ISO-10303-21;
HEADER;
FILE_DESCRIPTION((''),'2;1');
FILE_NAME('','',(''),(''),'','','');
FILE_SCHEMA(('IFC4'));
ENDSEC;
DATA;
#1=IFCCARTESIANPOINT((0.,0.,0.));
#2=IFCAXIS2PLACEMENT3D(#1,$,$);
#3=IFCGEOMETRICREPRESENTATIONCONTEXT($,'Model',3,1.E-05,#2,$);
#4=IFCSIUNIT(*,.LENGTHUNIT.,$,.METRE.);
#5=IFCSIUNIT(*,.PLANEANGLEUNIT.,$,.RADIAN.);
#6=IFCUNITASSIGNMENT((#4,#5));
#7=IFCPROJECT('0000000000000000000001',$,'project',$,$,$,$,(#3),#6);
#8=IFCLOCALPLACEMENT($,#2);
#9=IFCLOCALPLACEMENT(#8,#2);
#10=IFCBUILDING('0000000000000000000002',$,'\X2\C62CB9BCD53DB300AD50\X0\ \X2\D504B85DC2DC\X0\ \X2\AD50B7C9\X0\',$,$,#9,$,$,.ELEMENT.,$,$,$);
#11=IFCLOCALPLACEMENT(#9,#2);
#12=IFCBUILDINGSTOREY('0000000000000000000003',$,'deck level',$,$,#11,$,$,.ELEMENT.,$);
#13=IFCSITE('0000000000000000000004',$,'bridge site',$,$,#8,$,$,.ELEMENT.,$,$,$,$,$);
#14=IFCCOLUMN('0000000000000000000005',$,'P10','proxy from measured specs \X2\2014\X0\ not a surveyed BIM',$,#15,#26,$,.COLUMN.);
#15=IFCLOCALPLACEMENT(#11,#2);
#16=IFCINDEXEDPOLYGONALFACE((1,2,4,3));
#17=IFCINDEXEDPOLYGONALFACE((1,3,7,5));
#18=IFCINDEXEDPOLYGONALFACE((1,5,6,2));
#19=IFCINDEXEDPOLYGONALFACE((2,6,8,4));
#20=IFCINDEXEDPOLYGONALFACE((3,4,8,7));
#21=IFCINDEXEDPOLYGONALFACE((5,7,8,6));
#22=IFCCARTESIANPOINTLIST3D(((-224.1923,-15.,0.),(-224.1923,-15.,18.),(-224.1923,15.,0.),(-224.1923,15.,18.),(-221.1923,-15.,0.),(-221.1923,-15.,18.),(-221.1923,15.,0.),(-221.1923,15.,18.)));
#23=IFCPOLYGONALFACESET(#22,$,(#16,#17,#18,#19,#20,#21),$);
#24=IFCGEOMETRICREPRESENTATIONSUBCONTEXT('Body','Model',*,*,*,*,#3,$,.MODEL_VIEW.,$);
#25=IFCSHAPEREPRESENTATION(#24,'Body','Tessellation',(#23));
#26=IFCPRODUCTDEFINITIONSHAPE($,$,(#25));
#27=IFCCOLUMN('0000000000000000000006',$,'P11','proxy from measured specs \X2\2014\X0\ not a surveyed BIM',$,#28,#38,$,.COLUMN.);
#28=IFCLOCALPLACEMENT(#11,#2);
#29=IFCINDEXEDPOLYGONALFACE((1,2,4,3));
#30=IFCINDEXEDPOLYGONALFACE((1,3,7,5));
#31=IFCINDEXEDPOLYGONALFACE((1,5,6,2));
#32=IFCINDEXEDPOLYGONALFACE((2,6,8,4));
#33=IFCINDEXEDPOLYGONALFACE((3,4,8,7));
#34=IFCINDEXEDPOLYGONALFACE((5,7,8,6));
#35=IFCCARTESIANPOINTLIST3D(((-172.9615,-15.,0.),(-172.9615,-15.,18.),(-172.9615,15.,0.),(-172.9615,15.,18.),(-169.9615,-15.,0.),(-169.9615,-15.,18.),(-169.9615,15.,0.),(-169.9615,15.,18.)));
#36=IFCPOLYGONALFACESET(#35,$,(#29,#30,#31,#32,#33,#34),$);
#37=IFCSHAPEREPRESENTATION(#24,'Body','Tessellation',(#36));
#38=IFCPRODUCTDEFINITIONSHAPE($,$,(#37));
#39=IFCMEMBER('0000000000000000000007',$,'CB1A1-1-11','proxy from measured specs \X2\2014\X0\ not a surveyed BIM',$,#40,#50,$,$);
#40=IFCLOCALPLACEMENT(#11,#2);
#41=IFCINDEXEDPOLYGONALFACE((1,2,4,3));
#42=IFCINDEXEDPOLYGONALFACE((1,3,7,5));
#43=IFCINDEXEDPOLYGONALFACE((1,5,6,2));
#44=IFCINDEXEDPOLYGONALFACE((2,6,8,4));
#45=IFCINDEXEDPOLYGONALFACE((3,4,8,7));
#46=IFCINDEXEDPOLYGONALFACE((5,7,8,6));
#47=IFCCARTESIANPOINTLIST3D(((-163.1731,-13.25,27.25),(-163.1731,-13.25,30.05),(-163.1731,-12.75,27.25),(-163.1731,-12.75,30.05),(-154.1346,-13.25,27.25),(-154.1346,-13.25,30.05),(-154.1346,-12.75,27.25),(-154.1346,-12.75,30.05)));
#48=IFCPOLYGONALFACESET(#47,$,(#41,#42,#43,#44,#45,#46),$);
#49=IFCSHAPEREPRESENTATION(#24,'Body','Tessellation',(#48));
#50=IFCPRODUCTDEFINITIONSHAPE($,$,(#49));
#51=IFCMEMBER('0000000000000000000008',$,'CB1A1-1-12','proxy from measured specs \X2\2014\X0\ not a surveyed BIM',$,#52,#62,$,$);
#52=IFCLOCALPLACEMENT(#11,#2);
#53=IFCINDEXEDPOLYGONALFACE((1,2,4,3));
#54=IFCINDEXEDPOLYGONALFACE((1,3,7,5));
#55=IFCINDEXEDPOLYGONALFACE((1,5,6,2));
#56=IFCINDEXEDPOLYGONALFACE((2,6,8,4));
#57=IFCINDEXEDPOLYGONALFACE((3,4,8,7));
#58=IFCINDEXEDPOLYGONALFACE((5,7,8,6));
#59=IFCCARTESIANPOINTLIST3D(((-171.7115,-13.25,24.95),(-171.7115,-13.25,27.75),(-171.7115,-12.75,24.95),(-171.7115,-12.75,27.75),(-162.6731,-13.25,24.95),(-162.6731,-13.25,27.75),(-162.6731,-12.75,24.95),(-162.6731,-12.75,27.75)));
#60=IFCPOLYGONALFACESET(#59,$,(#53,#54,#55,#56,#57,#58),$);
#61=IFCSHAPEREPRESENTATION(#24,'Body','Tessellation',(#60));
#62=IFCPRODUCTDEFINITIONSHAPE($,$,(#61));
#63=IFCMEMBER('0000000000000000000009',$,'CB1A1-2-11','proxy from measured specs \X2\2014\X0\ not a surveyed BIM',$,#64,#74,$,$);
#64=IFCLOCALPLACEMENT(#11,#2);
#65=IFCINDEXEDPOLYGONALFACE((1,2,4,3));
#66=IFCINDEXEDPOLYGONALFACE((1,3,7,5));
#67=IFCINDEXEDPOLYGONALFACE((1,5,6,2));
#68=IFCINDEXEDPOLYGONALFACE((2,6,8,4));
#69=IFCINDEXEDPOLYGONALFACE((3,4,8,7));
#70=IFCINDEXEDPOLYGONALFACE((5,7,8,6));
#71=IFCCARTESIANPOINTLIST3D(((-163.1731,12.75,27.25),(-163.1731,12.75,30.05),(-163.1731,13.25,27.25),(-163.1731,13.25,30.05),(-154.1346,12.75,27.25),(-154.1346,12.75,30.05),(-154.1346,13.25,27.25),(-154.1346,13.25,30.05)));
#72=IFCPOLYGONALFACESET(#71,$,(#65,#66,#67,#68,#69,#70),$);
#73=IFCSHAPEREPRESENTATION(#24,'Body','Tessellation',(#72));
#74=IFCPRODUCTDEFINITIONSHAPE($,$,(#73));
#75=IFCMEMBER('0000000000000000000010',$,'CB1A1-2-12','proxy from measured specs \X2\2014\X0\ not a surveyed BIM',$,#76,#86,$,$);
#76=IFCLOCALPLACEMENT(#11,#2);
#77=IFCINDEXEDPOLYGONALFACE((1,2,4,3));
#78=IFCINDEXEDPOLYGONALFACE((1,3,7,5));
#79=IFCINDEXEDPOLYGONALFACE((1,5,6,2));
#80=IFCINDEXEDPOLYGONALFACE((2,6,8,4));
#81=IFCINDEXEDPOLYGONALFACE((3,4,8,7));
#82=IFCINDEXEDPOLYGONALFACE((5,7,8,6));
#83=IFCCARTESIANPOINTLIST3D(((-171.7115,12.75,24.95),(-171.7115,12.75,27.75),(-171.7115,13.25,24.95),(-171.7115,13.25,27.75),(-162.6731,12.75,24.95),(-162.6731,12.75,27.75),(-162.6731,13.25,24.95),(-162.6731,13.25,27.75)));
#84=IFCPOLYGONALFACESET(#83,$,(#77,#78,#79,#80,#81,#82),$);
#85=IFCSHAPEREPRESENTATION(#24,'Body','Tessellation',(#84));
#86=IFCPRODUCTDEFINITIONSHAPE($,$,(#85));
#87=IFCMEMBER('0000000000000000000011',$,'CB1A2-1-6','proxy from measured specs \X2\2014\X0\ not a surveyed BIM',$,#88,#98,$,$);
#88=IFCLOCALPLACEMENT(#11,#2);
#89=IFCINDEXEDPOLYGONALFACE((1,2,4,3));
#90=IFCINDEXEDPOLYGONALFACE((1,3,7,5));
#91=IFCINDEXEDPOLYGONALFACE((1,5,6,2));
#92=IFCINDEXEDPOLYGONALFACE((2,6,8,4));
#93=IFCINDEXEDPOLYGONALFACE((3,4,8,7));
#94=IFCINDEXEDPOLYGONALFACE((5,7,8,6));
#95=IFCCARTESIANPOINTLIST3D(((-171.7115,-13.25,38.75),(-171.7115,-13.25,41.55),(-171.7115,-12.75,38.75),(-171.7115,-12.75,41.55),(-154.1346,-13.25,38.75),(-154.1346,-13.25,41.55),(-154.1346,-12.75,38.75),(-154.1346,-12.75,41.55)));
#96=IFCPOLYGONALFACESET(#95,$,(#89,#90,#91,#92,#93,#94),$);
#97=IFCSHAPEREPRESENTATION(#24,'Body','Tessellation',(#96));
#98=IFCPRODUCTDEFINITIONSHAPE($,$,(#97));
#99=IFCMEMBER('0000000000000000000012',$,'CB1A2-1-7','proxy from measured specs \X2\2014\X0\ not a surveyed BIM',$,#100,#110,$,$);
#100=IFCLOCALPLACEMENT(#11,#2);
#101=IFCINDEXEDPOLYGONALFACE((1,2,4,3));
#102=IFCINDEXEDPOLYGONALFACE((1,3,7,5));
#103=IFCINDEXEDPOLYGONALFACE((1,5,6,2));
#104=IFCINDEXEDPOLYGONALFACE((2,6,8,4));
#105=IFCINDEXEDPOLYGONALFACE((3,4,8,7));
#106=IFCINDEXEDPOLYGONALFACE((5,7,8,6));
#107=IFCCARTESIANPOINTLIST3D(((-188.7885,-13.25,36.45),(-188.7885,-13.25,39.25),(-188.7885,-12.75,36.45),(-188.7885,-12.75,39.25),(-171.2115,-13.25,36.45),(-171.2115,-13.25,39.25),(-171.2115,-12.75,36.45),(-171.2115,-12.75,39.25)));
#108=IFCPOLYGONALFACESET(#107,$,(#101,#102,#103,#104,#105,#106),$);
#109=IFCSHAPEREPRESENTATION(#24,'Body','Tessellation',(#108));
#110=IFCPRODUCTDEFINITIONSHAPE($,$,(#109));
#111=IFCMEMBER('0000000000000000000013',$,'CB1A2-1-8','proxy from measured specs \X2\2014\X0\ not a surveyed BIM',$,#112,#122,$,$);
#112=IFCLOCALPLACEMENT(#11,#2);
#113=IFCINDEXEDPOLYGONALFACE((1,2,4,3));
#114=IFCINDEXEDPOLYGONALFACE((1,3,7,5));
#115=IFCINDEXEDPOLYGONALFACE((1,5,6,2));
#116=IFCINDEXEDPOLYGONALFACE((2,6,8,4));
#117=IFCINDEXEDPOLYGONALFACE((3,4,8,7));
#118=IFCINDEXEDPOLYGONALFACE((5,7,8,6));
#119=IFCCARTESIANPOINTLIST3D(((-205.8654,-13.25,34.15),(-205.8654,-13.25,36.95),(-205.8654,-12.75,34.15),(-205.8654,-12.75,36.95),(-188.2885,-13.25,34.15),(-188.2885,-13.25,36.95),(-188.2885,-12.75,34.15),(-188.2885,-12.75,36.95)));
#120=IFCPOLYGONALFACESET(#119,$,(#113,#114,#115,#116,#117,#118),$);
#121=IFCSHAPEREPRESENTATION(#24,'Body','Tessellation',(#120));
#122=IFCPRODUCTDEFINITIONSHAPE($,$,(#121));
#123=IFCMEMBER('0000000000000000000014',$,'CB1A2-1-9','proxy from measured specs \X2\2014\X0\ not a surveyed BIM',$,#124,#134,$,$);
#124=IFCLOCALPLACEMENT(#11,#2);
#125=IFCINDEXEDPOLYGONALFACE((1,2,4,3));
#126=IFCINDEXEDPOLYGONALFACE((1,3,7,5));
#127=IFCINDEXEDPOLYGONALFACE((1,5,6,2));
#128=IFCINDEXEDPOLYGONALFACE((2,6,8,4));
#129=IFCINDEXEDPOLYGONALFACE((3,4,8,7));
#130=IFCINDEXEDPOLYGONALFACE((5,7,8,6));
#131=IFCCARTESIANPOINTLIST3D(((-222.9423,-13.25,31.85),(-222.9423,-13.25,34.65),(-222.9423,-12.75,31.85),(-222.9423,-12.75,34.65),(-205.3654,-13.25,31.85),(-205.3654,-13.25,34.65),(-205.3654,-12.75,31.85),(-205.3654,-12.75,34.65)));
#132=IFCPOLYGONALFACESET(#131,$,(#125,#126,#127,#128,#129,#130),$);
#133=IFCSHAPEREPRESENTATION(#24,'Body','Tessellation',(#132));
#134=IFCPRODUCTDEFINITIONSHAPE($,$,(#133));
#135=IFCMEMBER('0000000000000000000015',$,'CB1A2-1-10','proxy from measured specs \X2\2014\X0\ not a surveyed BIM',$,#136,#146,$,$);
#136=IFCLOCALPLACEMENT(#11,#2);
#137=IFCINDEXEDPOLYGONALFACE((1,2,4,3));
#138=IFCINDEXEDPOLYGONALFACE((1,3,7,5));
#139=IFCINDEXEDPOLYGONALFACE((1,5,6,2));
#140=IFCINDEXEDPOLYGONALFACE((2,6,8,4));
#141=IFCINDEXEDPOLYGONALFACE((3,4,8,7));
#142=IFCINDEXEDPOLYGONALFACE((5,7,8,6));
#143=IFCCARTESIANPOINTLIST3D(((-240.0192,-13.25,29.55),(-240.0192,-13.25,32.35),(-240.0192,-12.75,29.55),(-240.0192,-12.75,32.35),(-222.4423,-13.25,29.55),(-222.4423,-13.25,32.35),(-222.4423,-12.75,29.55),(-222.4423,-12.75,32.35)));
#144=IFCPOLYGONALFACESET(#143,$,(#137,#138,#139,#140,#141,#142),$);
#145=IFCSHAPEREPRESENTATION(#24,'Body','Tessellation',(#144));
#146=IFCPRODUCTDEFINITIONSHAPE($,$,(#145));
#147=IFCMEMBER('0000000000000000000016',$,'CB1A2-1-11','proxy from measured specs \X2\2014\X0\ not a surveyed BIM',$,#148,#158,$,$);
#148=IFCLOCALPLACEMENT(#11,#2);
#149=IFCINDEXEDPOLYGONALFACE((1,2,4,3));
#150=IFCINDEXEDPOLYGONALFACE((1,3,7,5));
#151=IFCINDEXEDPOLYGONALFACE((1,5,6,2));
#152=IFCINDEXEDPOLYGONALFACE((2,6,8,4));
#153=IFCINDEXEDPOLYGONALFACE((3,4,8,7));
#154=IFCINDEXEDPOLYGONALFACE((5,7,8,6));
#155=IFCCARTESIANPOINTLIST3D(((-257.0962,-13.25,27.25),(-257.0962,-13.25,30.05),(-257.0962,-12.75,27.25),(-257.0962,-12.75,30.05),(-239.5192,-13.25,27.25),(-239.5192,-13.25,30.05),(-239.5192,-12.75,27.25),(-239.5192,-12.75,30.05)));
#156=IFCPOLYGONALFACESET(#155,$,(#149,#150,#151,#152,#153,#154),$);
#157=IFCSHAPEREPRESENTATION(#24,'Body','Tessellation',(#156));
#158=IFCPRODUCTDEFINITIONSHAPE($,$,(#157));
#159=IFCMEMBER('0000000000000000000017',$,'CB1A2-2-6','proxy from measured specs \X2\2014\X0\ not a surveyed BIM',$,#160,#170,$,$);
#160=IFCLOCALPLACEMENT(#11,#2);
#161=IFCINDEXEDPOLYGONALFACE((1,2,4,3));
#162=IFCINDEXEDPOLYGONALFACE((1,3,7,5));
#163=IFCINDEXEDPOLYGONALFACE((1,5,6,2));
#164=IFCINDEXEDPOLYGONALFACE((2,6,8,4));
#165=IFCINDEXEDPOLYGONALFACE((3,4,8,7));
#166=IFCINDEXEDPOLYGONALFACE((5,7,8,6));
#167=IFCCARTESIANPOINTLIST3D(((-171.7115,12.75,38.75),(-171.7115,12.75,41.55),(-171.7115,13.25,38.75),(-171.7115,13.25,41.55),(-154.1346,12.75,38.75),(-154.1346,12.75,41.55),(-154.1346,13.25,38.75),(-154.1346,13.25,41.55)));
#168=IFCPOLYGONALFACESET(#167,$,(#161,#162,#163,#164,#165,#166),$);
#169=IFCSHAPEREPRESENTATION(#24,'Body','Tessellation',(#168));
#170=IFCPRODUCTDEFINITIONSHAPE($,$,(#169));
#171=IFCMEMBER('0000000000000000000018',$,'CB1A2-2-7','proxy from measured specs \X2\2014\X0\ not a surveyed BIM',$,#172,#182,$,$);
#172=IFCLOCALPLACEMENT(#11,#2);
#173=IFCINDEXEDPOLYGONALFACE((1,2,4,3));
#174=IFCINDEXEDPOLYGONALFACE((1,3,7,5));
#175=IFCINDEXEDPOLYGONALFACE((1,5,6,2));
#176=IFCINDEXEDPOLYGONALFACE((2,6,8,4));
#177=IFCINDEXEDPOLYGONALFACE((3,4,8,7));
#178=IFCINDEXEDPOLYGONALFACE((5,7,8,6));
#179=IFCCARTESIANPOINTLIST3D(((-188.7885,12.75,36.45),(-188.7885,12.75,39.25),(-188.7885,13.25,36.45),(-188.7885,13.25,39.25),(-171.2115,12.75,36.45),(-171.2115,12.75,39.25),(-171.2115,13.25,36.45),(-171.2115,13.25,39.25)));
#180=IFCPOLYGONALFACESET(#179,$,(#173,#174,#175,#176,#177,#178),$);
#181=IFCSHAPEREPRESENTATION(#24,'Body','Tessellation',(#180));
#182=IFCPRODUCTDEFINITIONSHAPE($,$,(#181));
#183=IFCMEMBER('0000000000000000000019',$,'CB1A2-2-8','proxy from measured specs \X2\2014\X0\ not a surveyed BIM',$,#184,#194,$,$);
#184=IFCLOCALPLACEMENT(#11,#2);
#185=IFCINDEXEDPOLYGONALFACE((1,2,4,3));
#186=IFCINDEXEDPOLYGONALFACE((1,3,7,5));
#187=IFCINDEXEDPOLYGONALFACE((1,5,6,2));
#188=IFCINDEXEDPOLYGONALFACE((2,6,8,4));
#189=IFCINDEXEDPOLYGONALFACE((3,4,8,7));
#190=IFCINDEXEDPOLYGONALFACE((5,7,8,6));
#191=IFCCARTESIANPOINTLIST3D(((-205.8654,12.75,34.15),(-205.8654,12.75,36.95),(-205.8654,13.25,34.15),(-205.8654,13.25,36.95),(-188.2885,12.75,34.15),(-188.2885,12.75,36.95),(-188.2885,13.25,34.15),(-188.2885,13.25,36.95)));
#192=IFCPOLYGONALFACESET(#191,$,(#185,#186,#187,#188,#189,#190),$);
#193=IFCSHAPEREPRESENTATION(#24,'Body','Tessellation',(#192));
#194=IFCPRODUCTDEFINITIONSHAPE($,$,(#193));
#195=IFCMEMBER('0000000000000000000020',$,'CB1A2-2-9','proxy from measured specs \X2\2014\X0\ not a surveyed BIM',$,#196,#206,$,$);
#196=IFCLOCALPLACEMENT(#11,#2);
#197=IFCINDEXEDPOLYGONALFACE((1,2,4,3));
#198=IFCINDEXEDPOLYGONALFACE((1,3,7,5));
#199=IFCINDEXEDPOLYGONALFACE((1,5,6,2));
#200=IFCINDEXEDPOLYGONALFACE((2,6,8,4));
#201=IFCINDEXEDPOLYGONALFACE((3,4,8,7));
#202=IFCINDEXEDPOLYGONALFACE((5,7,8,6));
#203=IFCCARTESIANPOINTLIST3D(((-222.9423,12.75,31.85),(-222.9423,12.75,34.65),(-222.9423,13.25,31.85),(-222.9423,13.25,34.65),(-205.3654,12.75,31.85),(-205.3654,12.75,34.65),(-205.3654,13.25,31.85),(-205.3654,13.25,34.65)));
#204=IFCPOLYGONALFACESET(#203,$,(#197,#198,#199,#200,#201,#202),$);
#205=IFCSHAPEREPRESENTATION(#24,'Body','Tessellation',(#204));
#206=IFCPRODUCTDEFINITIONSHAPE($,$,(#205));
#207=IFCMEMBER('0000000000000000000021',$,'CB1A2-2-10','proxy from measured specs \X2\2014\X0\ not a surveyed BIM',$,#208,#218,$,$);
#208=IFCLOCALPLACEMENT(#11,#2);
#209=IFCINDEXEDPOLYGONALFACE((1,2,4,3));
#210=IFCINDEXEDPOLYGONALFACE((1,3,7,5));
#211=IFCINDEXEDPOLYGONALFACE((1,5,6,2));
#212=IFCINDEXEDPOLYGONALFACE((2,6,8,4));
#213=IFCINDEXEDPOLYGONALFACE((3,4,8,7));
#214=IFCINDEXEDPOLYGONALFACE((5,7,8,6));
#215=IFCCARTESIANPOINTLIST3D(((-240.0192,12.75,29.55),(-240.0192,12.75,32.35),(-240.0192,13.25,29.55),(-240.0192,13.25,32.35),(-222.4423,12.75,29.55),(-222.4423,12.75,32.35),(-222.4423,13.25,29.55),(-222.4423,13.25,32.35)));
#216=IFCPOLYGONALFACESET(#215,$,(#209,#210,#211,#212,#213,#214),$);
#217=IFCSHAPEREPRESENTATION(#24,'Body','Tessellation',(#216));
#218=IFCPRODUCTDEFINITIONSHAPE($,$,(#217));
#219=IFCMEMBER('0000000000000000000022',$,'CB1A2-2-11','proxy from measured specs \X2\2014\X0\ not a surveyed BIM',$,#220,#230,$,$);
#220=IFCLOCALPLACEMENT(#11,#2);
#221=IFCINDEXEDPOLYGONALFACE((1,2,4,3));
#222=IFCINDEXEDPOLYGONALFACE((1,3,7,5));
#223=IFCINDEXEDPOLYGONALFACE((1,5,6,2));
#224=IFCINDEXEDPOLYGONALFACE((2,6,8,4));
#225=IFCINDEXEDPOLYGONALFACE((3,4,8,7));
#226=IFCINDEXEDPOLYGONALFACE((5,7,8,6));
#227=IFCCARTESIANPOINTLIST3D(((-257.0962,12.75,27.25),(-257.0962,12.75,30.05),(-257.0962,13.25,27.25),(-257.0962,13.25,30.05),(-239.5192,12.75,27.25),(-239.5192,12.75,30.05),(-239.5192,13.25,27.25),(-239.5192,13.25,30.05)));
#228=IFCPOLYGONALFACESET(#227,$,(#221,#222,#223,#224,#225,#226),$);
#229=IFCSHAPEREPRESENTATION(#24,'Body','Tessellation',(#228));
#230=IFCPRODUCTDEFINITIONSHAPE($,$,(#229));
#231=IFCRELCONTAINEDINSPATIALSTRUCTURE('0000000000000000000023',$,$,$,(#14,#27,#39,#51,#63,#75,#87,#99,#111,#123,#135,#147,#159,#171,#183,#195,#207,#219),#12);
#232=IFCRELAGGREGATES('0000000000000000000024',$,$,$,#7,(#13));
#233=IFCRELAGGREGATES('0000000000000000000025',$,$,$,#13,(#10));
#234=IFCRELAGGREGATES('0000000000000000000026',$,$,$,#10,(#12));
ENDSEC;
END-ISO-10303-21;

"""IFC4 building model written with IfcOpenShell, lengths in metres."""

from ifc_helpers import new_model, si_unit, frame, origin, origin_2d, place, context, subcontext, project, spatial, rectangle, extrude, element, save


model = new_model("IFC4")

# Units and contexts
model_context = context("Model", 3, precision=1e-05, world=origin())
body_context = subcontext(model_context, "Body", "Model", "MODEL_VIEW")
ifc_project = project(units=[si_unit("LENGTHUNIT", "METRE"), si_unit("PLANEANGLEUNIT", "RADIAN")], contexts=[model_context])

# Site, building, storey
site_placement = place(None, origin())
site = spatial("IfcSite", under=ifc_project, at=site_placement, Name="bridge site", CompositionType="ELEMENT")
building_placement = place(site_placement, origin())
building = spatial("IfcBuilding", under=site, at=building_placement, Name="올림픽대교 프록시 교량", CompositionType="ELEMENT")
storey_placement = place(building_placement, origin())
storey = spatial("IfcBuildingStorey", under=building, at=storey_placement, Name="deck level", CompositionType="ELEMENT")

# Columns
for number, where, name in (
    (1, (-222.6923, 0.0, 0.0), "P10"),
    (2, (-171.4615, 0.0, 0.0), "P11"),
):
    element("IfcColumn", number, at=place(storey_placement, frame(where)), inside=storey, Name=name, Description="proxy from measured specs — not a surveyed BIM", PredefinedType="COLUMN", context=body_context, shape_type="SweptSolid", body=[
        extrude(rectangle(XDim=3.0, YDim=30.0, at=origin_2d()), origin(), (0.0, 0.0, 1.0), 18.0),
    ])

# Members
member_1_placement = place(storey_placement, frame((-158.6538, -13.0, 27.25)))
element("IfcMember", 3, at=member_1_placement, inside=storey, Name="CB1A1-1-11", Description="proxy from measured specs — not a surveyed BIM", context=body_context, shape_type="SweptSolid", body=[
    extrude(rectangle(XDim=9.0385, YDim=0.5, at=origin_2d()), origin(), (0.0, 0.0, 1.0), 2.8),
])
member_2_placement = place(storey_placement, frame((-167.1923, -13.0, 24.95)))
element("IfcMember", 4, at=member_2_placement, inside=storey, Name="CB1A1-1-12", Description="proxy from measured specs — not a surveyed BIM", context=body_context, shape_type="SweptSolid", body=[
    extrude(rectangle(XDim=9.0385, YDim=0.5, at=origin_2d()), origin(), (0.0, 0.0, 1.0), 2.8),
])
member_3_placement = place(storey_placement, frame((-158.6538, 13.0, 27.25)))
element("IfcMember", 5, at=member_3_placement, inside=storey, Name="CB1A1-2-11", Description="proxy from measured specs — not a surveyed BIM", context=body_context, shape_type="SweptSolid", body=[
    extrude(rectangle(XDim=9.0385, YDim=0.5, at=origin_2d()), origin(), (0.0, 0.0, 1.0), 2.8),
])
member_4_placement = place(storey_placement, frame((-167.1923, 13.0, 24.95)))
element("IfcMember", 6, at=member_4_placement, inside=storey, Name="CB1A1-2-12", Description="proxy from measured specs — not a surveyed BIM", context=body_context, shape_type="SweptSolid", body=[
    extrude(rectangle(XDim=9.0385, YDim=0.5, at=origin_2d()), origin(), (0.0, 0.0, 1.0), 2.8),
])
for number, where, name in (
    (7, (-162.9231, -13.0, 38.75), "CB1A2-1-6"),
    (8, (-180.0, -13.0, 36.45), "CB1A2-1-7"),
):
    element("IfcMember", number, at=place(storey_placement, frame(where)), inside=storey, Name=name, Description="proxy from measured specs — not a surveyed BIM", context=body_context, shape_type="SweptSolid", body=[
        extrude(rectangle(XDim=17.5769, YDim=0.5, at=origin_2d()), origin(), (0.0, 0.0, 1.0), 2.8),
    ])
for number, where, name in (
    (9, (-197.0769, -13.0, 34.15), "CB1A2-1-8"),
    (10, (-214.1538, -13.0, 31.85), "CB1A2-1-9"),
):
    element("IfcMember", number, at=place(storey_placement, frame(where)), inside=storey, Name=name, Description="proxy from measured specs — not a surveyed BIM", context=body_context, shape_type="SweptSolid", body=[
        extrude(rectangle(XDim=17.5769, YDim=0.5, at=origin_2d()), origin(), (0.0, 0.0, 1.0), 2.8),
    ])
for number, where, name in (
    (11, (-231.2308, -13.0, 29.55), "CB1A2-1-10"),
    (12, (-248.3077, -13.0, 27.25), "CB1A2-1-11"),
):
    element("IfcMember", number, at=place(storey_placement, frame(where)), inside=storey, Name=name, Description="proxy from measured specs — not a surveyed BIM", context=body_context, shape_type="SweptSolid", body=[
        extrude(rectangle(XDim=17.5769, YDim=0.5, at=origin_2d()), origin(), (0.0, 0.0, 1.0), 2.8),
    ])
for number, where, name in (
    (13, (-162.9231, 13.0, 38.75), "CB1A2-2-6"),
    (14, (-180.0, 13.0, 36.45), "CB1A2-2-7"),
):
    element("IfcMember", number, at=place(storey_placement, frame(where)), inside=storey, Name=name, Description="proxy from measured specs — not a surveyed BIM", context=body_context, shape_type="SweptSolid", body=[
        extrude(rectangle(XDim=17.5769, YDim=0.5, at=origin_2d()), origin(), (0.0, 0.0, 1.0), 2.8),
    ])
for number, where, name in (
    (15, (-197.0769, 13.0, 34.15), "CB1A2-2-8"),
    (16, (-214.1538, 13.0, 31.85), "CB1A2-2-9"),
):
    element("IfcMember", number, at=place(storey_placement, frame(where)), inside=storey, Name=name, Description="proxy from measured specs — not a surveyed BIM", context=body_context, shape_type="SweptSolid", body=[
        extrude(rectangle(XDim=17.5769, YDim=0.5, at=origin_2d()), origin(), (0.0, 0.0, 1.0), 2.8),
    ])
for number, where, name in (
    (17, (-231.2308, 13.0, 29.55), "CB1A2-2-10"),
    (18, (-248.3077, 13.0, 27.25), "CB1A2-2-11"),
):
    element("IfcMember", number, at=place(storey_placement, frame(where)), inside=storey, Name=name, Description="proxy from measured specs — not a surveyed BIM", context=body_context, shape_type="SweptSolid", body=[
        extrude(rectangle(XDim=17.5769, YDim=0.5, at=origin_2d()), origin(), (0.0, 0.0, 1.0), 2.8),
    ])

save(model, "model.ifc")
